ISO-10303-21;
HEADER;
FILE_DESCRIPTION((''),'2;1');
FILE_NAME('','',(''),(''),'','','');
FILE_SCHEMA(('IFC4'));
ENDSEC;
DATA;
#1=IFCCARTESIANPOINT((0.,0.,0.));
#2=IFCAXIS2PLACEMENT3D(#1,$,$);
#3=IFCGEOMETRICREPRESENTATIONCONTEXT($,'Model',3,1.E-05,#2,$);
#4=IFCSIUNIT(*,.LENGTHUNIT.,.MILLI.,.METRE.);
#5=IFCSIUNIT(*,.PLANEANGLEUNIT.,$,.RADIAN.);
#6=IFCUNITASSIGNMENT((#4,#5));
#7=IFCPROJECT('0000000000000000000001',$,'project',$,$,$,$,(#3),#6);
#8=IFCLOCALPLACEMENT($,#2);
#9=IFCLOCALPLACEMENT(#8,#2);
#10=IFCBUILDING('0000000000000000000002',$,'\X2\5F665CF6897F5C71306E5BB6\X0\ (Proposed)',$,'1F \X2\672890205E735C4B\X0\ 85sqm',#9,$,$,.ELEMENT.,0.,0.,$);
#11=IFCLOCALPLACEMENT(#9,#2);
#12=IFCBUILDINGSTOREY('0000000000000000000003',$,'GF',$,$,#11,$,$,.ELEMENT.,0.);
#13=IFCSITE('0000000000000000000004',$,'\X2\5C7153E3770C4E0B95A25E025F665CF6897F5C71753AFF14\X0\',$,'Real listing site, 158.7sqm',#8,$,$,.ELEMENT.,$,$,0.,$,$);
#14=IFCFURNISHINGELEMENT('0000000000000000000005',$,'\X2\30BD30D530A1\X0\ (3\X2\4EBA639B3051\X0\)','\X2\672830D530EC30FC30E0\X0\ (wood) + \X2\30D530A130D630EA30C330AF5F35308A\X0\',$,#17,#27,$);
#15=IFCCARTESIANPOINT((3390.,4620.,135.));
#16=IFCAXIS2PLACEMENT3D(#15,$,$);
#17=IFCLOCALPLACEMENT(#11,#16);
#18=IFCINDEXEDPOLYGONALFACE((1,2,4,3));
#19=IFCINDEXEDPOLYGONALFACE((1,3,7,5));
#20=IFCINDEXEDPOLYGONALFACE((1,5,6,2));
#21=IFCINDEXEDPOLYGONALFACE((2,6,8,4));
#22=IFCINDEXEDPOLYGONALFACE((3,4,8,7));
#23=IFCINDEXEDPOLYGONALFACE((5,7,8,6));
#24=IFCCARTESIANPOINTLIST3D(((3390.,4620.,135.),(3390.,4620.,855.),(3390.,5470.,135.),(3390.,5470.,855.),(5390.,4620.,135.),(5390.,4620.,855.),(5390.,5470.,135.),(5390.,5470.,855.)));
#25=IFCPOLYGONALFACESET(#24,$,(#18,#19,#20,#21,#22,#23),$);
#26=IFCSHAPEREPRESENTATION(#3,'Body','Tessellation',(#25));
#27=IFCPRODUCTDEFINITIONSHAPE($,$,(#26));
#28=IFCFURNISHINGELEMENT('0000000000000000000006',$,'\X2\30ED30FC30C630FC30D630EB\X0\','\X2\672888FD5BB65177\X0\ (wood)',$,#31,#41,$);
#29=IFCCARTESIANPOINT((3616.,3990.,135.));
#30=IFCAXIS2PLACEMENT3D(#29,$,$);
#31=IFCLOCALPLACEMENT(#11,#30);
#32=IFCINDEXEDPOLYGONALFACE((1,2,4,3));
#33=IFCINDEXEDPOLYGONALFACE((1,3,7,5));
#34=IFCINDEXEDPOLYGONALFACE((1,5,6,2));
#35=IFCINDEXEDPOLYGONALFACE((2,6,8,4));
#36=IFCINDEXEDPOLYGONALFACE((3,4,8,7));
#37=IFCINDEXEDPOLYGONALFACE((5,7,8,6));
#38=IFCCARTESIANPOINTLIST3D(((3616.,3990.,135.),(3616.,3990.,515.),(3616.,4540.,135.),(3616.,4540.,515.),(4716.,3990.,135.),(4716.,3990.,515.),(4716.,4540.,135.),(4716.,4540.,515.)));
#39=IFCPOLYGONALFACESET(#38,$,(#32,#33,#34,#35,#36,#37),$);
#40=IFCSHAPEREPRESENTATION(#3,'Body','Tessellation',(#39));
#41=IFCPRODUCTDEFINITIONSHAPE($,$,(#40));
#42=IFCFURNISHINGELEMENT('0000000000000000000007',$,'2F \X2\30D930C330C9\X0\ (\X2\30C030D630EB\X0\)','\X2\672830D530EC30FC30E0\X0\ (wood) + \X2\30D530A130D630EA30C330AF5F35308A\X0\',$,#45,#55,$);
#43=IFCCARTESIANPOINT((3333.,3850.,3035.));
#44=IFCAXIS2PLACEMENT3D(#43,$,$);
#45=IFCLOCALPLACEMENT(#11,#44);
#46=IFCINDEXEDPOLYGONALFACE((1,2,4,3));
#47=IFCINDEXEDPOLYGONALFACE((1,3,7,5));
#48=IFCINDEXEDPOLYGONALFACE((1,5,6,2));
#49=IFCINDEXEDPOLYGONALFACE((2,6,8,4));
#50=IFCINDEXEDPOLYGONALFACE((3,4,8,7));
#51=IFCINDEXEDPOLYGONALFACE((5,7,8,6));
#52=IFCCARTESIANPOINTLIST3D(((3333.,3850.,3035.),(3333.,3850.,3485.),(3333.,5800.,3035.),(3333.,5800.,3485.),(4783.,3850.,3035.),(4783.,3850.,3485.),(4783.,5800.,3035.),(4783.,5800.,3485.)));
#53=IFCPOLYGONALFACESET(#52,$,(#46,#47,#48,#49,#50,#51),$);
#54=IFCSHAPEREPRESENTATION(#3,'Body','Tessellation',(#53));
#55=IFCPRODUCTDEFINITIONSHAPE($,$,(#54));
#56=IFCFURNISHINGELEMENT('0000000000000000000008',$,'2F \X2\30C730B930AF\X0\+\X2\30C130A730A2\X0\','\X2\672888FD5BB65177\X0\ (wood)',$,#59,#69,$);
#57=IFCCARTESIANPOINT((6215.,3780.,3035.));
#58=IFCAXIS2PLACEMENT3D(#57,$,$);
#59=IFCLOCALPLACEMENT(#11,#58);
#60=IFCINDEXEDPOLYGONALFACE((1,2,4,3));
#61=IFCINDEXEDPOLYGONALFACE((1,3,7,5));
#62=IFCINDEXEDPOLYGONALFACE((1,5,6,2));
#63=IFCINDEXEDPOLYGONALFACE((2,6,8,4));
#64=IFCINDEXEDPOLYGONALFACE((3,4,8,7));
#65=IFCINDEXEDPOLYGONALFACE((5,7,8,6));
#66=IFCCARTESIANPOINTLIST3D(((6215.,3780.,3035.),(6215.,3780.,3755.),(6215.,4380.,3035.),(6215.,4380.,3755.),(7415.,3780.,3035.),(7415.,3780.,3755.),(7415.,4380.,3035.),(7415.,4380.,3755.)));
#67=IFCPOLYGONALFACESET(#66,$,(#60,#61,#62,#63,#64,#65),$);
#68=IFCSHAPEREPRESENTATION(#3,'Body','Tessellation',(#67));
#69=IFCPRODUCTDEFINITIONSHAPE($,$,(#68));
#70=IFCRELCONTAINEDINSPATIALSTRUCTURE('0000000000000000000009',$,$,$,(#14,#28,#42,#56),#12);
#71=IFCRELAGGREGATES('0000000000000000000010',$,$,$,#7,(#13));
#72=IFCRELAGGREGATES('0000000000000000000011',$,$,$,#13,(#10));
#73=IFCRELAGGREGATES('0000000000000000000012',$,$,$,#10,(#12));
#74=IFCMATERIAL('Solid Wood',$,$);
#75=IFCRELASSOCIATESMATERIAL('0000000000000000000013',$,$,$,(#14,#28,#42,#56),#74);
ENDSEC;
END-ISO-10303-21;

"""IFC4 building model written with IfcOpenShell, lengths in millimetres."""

from ifc_helpers import new_model, si_unit, frame, frame_2d, origin, place, context, project, spatial, rectangle, extrude, material, element, save


model = new_model("IFC4")

# Units and contexts
model_context = context("Model", 3, precision=1e-05, world=origin())
ifc_project = project(units=[si_unit("LENGTHUNIT", "METRE", prefix="MILLI"), si_unit("PLANEANGLEUNIT", "RADIAN")], contexts=[model_context])

# Site, building, storey
site_placement = place(None, origin())
site = spatial("IfcSite", under=ifc_project, at=site_placement, Name="山口県下関市彦島西山町４", ObjectType="Real listing site, 158.7sqm", CompositionType="ELEMENT", RefElevation=0.0)
building_placement = place(site_placement, origin())
building = spatial("IfcBuilding", under=site, at=building_placement, Name="彦島西山の家 (Proposed)", ObjectType="1F 木造平屋 85sqm", CompositionType="ELEMENT", ElevationOfRefHeight=0.0, ElevationOfTerrain=0.0)
storey_placement = place(building_placement, origin())
storey = spatial("IfcBuildingStorey", under=building, at=storey_placement, Name="GF", CompositionType="ELEMENT", Elevation=0.0)

# Shared definitions
ifc_material_1 = material(Name="Solid Wood")

# Furnishing elements
furnishing_1_placement = place(storey_placement, frame((3390.0, 4620.0, 135.0)))
element("IfcFurnishingElement", 1, at=furnishing_1_placement, inside=storey, material=ifc_material_1, Name="ソファ (3人掛け)", Description="木フレーム (wood) + ファブリック張り", context=model_context, shape_type="SweptSolid", body=[
    extrude(rectangle(XDim=2000.0, YDim=850.0, at=frame_2d((1000.0, 425.0))), frame((3390.0, 4620.0, 135.0)), (0.0, 0.0, 1.0), 720.0),
])
furnishing_2_placement = place(storey_placement, frame((3616.0, 3990.0, 135.0)))
element("IfcFurnishingElement", 2, at=furnishing_2_placement, inside=storey, material=ifc_material_1, Name="ローテーブル", Description="木製家具 (wood)", context=model_context, shape_type="SweptSolid", body=[
    extrude(rectangle(XDim=1100.0, YDim=550.0, at=frame_2d((550.0, 275.0))), frame((3616.0, 3990.0, 135.0)), (0.0, 0.0, 1.0), 380.0),
])
furnishing_3_placement = place(storey_placement, frame((3333.0, 3850.0, 3035.0)))
element("IfcFurnishingElement", 3, at=furnishing_3_placement, inside=storey, material=ifc_material_1, Name="2F ベッド (ダブル)", Description="木フレーム (wood) + ファブリック張り", context=model_context, shape_type="SweptSolid", body=[
    extrude(rectangle(XDim=1450.0, YDim=1950.0, at=frame_2d((725.0, 975.0))), frame((3333.0, 3850.0, 3035.0)), (0.0, 0.0, 1.0), 450.0),
])
furnishing_4_placement = place(storey_placement, frame((6215.0, 3780.0, 3035.0)))
element("IfcFurnishingElement", 4, at=furnishing_4_placement, inside=storey, material=ifc_material_1, Name="2F デスク+チェア", Description="木製家具 (wood)", context=model_context, shape_type="SweptSolid", body=[
    extrude(rectangle(XDim=1200.0, YDim=600.0, at=frame_2d((600.0, 300.0))), frame((6215.0, 3780.0, 3035.0)), (0.0, 0.0, 1.0), 720.0),
])

save(model, "model.ifc")
